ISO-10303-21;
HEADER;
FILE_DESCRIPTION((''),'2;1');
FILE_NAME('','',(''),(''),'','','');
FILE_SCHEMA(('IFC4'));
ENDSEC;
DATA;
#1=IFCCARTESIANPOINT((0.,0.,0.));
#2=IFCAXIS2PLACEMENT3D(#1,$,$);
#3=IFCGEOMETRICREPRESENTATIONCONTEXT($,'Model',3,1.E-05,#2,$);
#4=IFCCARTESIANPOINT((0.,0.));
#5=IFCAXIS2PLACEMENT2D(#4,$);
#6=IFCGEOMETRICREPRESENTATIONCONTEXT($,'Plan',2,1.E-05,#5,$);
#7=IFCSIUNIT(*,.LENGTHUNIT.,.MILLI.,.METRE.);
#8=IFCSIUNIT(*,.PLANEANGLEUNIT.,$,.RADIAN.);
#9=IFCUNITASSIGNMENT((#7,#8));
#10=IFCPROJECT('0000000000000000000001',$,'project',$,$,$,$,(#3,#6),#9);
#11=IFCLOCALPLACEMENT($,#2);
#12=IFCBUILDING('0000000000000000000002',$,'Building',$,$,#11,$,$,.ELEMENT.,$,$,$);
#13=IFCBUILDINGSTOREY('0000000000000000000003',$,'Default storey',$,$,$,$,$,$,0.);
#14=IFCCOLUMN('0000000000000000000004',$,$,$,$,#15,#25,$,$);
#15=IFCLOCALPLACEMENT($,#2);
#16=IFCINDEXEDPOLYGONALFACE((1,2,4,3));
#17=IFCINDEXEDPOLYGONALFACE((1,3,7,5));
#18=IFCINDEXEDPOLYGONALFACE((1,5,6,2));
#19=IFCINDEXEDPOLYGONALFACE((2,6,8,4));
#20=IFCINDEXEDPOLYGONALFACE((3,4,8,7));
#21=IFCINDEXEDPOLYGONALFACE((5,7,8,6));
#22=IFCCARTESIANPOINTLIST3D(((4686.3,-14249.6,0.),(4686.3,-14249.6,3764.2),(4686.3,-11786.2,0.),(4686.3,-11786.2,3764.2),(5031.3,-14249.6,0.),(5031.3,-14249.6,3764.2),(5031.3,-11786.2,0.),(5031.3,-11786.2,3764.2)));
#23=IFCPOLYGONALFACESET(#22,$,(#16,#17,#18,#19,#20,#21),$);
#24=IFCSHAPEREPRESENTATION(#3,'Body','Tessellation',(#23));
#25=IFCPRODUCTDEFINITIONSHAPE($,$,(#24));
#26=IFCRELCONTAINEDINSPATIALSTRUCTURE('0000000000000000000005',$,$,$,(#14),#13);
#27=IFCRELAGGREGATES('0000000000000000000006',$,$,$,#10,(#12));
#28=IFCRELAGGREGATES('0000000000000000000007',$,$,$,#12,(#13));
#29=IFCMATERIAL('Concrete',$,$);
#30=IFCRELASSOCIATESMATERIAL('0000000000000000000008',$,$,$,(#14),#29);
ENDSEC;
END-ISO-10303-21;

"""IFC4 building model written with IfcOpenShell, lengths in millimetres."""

from ifc_helpers import new_model, si_unit, frame, origin, origin_2d, place, context, project, spatial, rectangle, extrude, material, element, save


model = new_model("IFC4")

# Units and contexts
model_context = context("Model", 3, precision=1e-05, world=origin())
plan_context = context("Plan", 2, precision=1e-05, world=origin_2d())
ifc_project = project(units=[si_unit("LENGTHUNIT", "METRE", prefix="MILLI"), si_unit("PLANEANGLEUNIT", "RADIAN")], contexts=[model_context, plan_context])

# Building, storey
placement = place(None, origin())
building = spatial("IfcBuilding", under=ifc_project, at=placement, Name="Building", CompositionType="ELEMENT")
storey = spatial("IfcBuildingStorey", under=building, Name="Default storey", Elevation=0.0)

# Column
ifc_material_1 = material(Name="Concrete")
element("IfcColumn", 1, at=placement, inside=storey, material=ifc_material_1, context=model_context, shape_type="SweptSolid", body=[
    extrude(rectangle(XDim=345.0, YDim=2463.4, at=origin_2d()), frame((4858.8, -13017.9, 0.0), z_axis=(0.0, 0.0, 1.0), x_axis=(1000.0, 0.0, 0.0)), (0.0, 0.0, 1.0), 3764.2),
])

save(model, "model.ifc")
